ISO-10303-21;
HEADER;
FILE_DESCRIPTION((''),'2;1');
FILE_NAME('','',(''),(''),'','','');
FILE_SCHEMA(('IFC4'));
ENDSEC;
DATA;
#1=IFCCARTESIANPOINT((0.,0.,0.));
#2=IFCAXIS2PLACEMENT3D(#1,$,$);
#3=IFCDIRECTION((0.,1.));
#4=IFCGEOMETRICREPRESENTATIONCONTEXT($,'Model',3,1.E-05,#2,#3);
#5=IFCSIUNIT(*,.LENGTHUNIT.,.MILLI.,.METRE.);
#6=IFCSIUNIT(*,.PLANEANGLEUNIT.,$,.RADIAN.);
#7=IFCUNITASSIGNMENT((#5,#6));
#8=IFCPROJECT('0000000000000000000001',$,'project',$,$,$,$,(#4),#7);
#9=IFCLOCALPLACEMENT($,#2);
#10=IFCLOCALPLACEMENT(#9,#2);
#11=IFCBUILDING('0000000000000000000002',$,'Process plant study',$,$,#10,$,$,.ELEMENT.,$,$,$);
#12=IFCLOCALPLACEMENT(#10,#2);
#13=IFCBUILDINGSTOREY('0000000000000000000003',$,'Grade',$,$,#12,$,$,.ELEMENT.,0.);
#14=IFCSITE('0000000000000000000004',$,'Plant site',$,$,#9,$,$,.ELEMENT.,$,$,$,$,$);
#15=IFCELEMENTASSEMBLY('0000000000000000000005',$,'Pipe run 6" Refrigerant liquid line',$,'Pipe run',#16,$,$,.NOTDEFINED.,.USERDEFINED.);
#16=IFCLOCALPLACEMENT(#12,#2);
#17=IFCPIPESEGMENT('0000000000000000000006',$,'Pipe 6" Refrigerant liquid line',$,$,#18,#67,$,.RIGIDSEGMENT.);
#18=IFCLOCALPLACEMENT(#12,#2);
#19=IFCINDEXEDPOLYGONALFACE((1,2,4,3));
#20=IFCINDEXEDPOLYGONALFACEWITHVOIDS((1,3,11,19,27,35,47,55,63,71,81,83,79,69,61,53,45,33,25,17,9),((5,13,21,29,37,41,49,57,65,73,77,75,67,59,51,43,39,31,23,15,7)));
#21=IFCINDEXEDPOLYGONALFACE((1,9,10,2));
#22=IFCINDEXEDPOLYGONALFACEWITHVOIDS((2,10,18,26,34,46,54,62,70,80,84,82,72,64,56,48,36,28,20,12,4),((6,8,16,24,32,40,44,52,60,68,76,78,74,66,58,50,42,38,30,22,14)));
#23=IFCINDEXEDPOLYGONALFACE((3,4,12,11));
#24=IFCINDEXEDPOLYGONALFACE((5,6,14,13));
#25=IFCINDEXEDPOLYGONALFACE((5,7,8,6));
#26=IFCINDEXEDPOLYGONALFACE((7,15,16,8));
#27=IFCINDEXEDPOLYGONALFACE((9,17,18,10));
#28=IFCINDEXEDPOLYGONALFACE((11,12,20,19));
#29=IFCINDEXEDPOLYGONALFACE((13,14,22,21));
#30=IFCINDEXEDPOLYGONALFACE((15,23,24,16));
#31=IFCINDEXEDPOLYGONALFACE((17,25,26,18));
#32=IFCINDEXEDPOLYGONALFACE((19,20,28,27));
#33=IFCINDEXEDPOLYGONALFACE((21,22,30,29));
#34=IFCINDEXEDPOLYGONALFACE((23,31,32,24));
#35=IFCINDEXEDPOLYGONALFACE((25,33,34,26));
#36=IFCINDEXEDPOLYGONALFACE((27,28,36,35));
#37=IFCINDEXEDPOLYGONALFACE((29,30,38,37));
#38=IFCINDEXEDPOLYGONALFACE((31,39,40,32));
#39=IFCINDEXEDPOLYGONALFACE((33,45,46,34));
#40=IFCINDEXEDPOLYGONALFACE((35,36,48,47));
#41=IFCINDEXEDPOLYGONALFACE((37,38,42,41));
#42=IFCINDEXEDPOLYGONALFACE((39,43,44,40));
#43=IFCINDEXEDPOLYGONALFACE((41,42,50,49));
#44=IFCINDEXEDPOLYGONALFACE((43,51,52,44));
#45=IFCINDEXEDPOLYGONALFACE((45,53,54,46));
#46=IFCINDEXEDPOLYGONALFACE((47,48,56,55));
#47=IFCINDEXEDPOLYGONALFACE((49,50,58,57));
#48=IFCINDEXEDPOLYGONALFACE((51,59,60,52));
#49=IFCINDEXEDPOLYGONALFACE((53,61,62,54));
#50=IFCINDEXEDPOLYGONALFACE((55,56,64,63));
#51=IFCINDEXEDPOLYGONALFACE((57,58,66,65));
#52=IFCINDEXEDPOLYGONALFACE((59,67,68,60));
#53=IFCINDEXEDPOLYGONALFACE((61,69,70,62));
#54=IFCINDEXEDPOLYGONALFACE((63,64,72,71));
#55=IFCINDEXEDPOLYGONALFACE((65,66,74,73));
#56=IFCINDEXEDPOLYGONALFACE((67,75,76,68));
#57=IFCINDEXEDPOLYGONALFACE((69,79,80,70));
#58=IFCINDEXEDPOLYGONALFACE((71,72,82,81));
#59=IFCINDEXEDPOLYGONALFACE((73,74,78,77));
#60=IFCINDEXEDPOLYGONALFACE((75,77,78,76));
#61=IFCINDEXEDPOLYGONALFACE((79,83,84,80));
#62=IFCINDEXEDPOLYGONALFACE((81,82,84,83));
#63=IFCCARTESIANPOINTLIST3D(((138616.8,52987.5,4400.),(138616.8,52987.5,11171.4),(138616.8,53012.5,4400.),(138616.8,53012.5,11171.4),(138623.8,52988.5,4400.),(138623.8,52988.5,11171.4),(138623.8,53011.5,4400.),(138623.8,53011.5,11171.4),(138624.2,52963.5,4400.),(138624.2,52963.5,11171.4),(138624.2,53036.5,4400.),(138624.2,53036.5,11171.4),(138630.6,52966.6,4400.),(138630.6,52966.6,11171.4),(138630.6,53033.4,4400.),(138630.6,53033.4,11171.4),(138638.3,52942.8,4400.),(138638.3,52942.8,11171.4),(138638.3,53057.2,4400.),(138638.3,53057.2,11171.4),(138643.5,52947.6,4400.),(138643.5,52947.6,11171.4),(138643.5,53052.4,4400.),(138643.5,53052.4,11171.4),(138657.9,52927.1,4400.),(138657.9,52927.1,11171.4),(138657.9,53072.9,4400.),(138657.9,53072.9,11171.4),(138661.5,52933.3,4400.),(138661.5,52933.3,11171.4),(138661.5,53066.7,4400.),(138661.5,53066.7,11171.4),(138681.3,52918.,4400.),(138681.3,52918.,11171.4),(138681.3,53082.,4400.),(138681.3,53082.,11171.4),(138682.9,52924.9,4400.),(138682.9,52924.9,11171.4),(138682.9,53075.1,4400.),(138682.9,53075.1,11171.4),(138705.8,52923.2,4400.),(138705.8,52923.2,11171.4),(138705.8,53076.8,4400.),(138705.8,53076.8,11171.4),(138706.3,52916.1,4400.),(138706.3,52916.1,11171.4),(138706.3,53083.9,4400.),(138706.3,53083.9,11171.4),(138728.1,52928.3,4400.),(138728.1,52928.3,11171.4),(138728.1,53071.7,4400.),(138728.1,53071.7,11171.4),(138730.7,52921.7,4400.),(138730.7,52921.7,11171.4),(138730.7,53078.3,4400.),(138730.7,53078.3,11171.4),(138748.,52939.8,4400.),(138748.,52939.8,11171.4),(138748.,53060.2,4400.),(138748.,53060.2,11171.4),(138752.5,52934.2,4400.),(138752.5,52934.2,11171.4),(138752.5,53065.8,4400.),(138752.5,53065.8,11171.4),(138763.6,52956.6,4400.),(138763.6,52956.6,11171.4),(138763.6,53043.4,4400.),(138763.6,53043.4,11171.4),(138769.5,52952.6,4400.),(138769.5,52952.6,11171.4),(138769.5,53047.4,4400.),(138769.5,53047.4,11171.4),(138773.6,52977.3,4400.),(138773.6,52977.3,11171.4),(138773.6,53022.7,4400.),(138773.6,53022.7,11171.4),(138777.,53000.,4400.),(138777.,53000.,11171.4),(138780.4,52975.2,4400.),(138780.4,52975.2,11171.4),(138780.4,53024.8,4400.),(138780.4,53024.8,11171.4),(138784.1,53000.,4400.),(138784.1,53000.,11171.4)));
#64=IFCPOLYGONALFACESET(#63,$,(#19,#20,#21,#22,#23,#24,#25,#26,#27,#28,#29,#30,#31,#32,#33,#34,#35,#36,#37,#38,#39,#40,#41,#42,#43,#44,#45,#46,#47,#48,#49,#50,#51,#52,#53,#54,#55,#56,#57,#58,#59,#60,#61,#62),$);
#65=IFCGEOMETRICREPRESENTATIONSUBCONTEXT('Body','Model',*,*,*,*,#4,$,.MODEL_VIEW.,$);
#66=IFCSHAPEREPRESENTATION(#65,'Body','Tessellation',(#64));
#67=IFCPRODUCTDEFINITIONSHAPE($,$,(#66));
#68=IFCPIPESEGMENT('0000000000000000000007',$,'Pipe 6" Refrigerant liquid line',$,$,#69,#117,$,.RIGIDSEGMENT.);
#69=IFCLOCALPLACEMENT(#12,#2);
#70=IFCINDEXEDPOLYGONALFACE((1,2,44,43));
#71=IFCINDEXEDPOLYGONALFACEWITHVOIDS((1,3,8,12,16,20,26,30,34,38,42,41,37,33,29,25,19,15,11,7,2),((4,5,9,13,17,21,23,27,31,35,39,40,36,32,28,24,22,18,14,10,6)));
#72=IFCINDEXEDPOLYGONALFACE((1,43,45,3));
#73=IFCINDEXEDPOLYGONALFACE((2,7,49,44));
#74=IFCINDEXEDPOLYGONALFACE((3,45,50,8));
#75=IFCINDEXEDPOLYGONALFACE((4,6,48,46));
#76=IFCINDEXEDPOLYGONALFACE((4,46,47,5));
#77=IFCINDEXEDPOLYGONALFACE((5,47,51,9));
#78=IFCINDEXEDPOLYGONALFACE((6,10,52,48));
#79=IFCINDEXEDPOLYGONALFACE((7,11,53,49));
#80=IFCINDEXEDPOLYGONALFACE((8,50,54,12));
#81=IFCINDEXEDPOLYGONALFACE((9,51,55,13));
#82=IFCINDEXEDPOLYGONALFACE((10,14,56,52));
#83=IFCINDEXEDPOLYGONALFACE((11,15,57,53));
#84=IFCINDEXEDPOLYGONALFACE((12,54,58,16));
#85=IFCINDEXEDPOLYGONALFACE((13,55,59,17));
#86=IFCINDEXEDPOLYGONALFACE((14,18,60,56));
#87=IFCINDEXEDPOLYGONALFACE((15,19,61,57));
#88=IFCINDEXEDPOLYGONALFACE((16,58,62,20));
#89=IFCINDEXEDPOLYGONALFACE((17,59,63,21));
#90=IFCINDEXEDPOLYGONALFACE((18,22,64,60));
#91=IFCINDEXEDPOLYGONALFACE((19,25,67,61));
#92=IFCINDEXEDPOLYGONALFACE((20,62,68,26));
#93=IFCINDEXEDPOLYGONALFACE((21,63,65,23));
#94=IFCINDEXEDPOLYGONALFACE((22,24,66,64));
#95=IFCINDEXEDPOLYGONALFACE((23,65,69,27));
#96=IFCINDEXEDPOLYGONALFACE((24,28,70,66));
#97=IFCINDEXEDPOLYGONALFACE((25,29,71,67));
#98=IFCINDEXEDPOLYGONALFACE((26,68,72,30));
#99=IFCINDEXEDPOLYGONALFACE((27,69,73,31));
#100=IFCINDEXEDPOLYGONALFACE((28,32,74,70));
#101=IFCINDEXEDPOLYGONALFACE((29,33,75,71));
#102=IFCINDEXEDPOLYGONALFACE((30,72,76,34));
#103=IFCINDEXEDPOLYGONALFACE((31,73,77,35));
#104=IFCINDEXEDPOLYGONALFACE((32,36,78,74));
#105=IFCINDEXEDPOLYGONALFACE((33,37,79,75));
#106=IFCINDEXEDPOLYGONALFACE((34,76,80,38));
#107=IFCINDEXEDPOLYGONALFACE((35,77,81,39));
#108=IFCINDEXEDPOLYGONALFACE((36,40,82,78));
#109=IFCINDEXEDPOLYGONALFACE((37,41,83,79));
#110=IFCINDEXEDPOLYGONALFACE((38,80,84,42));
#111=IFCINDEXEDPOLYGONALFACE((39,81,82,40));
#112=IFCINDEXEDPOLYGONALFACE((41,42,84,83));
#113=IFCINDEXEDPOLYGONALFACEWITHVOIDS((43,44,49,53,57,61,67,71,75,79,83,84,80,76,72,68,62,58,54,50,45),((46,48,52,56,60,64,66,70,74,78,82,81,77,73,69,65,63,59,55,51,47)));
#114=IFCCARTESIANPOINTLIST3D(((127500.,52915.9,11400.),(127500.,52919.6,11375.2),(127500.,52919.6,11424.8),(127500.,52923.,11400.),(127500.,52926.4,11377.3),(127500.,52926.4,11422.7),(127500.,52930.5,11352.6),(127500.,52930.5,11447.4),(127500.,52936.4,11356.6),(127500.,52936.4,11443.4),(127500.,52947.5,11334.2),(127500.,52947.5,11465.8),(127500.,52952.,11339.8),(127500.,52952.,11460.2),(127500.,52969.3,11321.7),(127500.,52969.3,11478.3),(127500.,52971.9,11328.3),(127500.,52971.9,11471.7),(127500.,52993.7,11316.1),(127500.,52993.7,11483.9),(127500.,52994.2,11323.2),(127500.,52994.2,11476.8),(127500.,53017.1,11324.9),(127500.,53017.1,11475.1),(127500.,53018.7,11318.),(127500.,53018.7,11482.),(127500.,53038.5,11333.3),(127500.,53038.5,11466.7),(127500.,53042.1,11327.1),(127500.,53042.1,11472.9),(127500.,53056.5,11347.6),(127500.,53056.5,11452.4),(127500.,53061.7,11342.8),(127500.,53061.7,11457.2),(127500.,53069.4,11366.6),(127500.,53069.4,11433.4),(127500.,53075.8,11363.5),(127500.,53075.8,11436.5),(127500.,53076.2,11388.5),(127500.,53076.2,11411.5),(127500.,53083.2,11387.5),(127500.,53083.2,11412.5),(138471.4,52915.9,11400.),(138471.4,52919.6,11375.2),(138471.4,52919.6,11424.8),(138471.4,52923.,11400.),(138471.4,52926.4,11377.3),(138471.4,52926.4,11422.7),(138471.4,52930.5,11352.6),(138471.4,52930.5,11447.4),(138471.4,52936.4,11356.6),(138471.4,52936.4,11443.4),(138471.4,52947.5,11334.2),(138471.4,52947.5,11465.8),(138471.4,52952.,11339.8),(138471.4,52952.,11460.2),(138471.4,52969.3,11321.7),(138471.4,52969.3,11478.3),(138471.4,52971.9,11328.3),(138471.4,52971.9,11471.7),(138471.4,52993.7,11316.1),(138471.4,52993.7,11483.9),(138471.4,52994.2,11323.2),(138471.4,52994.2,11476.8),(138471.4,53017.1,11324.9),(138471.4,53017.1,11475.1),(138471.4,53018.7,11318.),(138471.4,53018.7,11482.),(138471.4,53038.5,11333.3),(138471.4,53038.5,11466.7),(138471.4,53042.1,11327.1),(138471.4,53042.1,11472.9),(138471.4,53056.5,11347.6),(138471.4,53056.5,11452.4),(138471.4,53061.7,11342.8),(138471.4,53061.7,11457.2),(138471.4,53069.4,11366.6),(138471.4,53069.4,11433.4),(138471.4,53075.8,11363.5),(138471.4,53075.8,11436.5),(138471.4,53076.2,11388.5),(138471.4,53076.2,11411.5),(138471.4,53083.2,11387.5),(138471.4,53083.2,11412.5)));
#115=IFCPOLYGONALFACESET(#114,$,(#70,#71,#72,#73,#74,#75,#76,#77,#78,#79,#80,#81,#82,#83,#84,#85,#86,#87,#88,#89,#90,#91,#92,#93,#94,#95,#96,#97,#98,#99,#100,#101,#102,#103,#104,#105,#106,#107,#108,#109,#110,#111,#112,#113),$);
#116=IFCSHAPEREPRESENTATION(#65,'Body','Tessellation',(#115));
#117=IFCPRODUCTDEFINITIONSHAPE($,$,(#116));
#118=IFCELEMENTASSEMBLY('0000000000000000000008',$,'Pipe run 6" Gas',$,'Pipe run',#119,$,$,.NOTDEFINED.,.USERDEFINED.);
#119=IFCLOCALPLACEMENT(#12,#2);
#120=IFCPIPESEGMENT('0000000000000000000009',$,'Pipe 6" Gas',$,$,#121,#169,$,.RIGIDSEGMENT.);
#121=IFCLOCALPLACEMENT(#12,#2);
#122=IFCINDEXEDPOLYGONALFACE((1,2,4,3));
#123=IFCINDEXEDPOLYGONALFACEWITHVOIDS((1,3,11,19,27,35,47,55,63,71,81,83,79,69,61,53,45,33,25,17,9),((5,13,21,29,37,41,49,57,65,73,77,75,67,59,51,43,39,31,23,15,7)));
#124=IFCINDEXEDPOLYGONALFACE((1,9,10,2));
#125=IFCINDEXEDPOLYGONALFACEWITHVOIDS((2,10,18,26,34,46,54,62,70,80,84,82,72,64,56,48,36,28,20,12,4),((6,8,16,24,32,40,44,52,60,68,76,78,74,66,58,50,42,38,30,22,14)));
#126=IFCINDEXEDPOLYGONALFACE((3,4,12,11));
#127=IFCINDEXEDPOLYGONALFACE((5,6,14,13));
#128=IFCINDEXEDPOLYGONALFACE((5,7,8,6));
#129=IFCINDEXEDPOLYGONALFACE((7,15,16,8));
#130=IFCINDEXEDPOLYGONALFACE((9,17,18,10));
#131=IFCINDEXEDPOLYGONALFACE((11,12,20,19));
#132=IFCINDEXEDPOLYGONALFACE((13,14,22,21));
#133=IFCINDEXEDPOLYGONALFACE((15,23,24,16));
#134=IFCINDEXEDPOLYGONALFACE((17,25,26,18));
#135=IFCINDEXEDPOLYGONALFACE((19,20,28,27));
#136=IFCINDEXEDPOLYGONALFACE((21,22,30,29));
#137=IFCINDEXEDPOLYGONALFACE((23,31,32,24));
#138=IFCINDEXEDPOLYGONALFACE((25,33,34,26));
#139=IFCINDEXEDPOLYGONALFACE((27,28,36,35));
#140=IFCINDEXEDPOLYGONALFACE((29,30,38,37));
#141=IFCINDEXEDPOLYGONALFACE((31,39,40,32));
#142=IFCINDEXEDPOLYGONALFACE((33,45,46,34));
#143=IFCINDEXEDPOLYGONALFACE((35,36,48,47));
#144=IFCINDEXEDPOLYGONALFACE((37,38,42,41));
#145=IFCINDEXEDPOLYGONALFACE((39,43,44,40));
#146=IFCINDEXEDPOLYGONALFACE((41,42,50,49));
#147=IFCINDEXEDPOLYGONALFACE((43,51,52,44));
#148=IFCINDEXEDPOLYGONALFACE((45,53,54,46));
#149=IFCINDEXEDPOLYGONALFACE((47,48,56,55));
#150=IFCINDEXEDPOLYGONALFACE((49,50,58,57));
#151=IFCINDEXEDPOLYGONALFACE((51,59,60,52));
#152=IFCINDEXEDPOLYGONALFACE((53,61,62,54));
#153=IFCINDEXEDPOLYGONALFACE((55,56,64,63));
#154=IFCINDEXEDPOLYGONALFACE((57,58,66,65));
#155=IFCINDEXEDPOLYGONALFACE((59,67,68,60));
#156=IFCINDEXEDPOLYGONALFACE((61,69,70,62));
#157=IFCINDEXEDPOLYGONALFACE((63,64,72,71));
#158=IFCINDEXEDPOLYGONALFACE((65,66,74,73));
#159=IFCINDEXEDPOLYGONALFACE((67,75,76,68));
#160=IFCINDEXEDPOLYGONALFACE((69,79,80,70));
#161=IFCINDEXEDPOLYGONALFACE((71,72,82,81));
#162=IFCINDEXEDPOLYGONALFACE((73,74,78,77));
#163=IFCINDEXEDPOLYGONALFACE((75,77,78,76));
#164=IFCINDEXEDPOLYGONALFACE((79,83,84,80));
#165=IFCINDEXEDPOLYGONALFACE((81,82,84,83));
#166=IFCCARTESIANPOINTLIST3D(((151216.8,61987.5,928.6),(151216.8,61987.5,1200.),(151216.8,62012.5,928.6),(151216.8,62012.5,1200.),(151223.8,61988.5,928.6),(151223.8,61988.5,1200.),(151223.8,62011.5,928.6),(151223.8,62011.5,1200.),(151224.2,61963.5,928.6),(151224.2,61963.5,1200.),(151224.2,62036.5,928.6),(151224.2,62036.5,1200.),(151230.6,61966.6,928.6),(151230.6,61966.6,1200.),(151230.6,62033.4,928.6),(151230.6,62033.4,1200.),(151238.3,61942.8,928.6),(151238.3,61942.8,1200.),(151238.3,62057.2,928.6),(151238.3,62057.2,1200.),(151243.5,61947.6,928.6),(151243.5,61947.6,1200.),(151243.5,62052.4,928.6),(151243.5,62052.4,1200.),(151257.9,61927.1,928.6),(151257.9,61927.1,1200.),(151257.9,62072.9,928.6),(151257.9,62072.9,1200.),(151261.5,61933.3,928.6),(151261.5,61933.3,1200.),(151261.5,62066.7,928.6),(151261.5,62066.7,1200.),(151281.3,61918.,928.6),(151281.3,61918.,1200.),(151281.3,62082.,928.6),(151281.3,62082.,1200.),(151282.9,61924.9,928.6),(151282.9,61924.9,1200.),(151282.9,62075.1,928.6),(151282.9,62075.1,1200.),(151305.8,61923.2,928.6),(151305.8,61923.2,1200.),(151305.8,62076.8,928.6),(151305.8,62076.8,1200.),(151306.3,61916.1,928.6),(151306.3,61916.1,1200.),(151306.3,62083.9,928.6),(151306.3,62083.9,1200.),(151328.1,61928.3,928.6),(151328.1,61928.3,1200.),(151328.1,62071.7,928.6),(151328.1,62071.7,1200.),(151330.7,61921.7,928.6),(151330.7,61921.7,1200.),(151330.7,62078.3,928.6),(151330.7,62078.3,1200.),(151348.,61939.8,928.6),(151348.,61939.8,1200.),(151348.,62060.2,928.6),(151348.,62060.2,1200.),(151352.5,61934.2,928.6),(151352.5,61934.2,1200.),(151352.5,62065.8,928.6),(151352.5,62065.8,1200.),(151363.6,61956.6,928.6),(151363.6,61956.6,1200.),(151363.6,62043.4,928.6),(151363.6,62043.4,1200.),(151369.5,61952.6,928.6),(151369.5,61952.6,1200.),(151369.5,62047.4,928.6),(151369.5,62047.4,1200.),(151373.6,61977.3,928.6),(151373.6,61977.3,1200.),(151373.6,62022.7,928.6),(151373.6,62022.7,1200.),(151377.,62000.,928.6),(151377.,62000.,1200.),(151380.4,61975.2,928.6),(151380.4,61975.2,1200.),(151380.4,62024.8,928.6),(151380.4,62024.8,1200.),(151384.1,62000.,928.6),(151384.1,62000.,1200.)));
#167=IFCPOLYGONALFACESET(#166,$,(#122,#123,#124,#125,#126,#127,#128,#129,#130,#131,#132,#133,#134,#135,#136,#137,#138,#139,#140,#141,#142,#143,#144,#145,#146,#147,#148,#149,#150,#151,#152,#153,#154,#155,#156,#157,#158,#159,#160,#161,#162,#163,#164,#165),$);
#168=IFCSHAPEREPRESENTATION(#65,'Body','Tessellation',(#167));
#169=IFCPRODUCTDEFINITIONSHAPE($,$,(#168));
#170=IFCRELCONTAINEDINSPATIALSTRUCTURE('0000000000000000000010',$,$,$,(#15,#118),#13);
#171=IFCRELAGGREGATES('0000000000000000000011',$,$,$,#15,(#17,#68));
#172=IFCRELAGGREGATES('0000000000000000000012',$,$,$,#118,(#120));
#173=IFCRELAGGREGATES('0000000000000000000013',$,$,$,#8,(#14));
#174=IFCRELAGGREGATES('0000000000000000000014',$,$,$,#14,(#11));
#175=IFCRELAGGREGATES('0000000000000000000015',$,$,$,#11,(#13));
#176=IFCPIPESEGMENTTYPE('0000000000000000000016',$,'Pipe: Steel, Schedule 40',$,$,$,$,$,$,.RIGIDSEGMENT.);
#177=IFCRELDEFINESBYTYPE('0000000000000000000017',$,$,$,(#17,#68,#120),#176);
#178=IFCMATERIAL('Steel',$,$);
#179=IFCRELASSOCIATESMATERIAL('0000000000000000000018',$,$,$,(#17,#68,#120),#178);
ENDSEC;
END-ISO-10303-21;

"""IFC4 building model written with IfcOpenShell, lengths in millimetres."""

from ifc_helpers import new_model, si_unit, direction, frame, origin, origin_with_axes, origin_2d, place, context, subcontext, project, spatial, hollow_circle, extrude, material, type_object, element, aggregate, save


model = new_model("IFC4")

# Units and contexts
model_context = context("Model", 3, precision=1e-05, world=origin(), true_north=direction((0.0, 1.0)))
body_context = subcontext(model_context, "Body", "Model", "MODEL_VIEW")
ifc_project = project(units=[si_unit("LENGTHUNIT", "METRE", prefix="MILLI"), si_unit("PLANEANGLEUNIT", "RADIAN")], contexts=[model_context])

# Site, building, storey
site_placement = place(None, origin())
site = spatial("IfcSite", under=ifc_project, at=site_placement, Name="Plant site", CompositionType="ELEMENT")
building_placement = place(site_placement, origin())
building = spatial("IfcBuilding", under=site, at=building_placement, Name="Process plant study", CompositionType="ELEMENT")
storey_placement = place(building_placement, origin())
storey = spatial("IfcBuildingStorey", under=building, at=storey_placement, Name="Grade", CompositionType="ELEMENT", Elevation=0.0)

# Element assemblies, pipe segments
ifc_material = material(Name="Steel")
pipe_segment_type = type_object("IfcPipeSegmentType", Name="Pipe: Steel, Schedule 40", PredefinedType="RIGIDSEGMENT")
assembly_1_placement = place(storey_placement, origin_with_axes())
assembly_1 = element("IfcElementAssembly", 1, at=assembly_1_placement, inside=storey, Name="Pipe run 6\" Refrigerant liquid line", ObjectType="Pipe run", AssemblyPlace="NOTDEFINED", PredefinedType="USERDEFINED")
pipe_segment_1_placement = place(storey_placement, origin_with_axes())
pipe_segment_1 = element("IfcPipeSegment", 2, at=pipe_segment_1_placement, type_object=pipe_segment_type, material=ifc_material, Name="Pipe 6\" Refrigerant liquid line", PredefinedType="RIGIDSEGMENT", context=body_context, shape_type="SweptSolid", body=[
    extrude(hollow_circle(Radius=84.1, WallThickness=7.1, at=origin_2d()), frame((138700.0, 53000.0, 4400.0), z_axis=(0.0, 0.0, 1.0), x_axis=(1.0, 0.0, 0.0)), (0.0, 0.0, 1.0), 6771.4),
])
pipe_segment_2_placement = place(storey_placement, origin_with_axes())
pipe_segment_2 = element("IfcPipeSegment", 3, at=pipe_segment_2_placement, type_object=pipe_segment_type, material=ifc_material, Name="Pipe 6\" Refrigerant liquid line", PredefinedType="RIGIDSEGMENT", context=body_context, shape_type="SweptSolid", body=[
    extrude(hollow_circle(Radius=84.1, WallThickness=7.1, at=origin_2d()), frame((138471.4, 53000.0, 11400.0), z_axis=(-1.0, 0.0, 0.0), x_axis=(0.0, -1.0, 0.0)), (0.0, 0.0, 1.0), 10971.4),
])
assembly_2_placement = place(storey_placement, origin_with_axes())
assembly_2 = element("IfcElementAssembly", 4, at=assembly_2_placement, inside=storey, Name="Pipe run 6\" Gas", ObjectType="Pipe run", AssemblyPlace="NOTDEFINED", PredefinedType="USERDEFINED")
pipe_segment_3_placement = place(storey_placement, origin_with_axes())
pipe_segment_3 = element("IfcPipeSegment", 5, at=pipe_segment_3_placement, type_object=pipe_segment_type, material=ifc_material, Name="Pipe 6\" Gas", PredefinedType="RIGIDSEGMENT", context=body_context, shape_type="SweptSolid", body=[
    extrude(hollow_circle(Radius=84.1, WallThickness=7.1, at=origin_2d()), frame((151300.0, 62000.0, 1200.0), z_axis=(0.0, 0.0, -1.0), x_axis=(1.0, 0.0, 0.0)), (0.0, 0.0, 1.0), 271.4),
])

aggregate(assembly_1, [pipe_segment_1, pipe_segment_2])
aggregate(assembly_2, [pipe_segment_3])

save(model, "model.ifc")
